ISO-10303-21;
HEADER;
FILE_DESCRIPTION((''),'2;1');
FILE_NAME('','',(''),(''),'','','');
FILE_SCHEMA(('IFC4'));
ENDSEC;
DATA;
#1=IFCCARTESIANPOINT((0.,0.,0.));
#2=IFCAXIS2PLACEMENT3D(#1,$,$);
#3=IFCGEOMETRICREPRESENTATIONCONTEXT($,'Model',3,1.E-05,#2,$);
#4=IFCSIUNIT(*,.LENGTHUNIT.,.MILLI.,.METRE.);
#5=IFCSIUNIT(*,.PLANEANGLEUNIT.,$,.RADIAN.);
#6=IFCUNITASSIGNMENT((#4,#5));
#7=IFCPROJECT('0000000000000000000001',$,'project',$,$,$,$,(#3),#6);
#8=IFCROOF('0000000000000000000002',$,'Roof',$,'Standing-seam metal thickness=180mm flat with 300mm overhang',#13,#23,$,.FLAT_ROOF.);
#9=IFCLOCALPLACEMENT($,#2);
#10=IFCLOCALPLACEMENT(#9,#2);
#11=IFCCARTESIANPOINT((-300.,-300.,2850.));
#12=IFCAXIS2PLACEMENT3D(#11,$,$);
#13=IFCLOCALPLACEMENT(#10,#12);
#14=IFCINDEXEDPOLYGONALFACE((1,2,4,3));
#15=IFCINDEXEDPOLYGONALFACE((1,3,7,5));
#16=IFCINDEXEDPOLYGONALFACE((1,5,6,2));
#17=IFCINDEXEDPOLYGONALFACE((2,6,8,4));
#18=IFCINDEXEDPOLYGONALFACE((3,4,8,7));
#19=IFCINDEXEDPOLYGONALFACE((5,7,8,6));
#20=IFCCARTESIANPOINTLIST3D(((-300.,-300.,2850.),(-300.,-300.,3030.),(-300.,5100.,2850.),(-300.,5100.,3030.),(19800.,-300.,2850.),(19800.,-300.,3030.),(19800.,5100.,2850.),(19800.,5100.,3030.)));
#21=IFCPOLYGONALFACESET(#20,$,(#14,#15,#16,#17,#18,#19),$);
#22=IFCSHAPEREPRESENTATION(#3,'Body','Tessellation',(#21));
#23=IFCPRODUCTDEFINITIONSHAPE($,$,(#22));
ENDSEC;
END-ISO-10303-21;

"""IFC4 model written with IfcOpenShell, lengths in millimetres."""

from ifc_helpers import new_model, si_unit, frame, frame_2d, origin, place, context, project, rectangle, extrude, element, save


model = new_model("IFC4")

# Units and contexts
model_context = context("Model", 3, precision=1e-05, world=origin())
ifc_project = project(units=[si_unit("LENGTHUNIT", "METRE", prefix="MILLI"), si_unit("PLANEANGLEUNIT", "RADIAN")], contexts=[model_context])

# Roof
placement_1 = place(None, origin())
placement_2 = place(placement_1, origin())
roof_placement = place(placement_2, frame((-300.0, -300.0, 2850.0)))
element("IfcRoof", 1, at=roof_placement, Name="Roof", ObjectType="Standing-seam metal thickness=180mm flat with 300mm overhang", PredefinedType="FLAT_ROOF", context=model_context, shape_type="SweptSolid", body=[
    extrude(rectangle(XDim=20100.0, YDim=5400.0, at=frame_2d((10050.0, 2700.0))), frame((-300.0, -300.0, 2850.0)), (0.0, 0.0, 1.0), 180.0),
])

save(model, "model.ifc")
